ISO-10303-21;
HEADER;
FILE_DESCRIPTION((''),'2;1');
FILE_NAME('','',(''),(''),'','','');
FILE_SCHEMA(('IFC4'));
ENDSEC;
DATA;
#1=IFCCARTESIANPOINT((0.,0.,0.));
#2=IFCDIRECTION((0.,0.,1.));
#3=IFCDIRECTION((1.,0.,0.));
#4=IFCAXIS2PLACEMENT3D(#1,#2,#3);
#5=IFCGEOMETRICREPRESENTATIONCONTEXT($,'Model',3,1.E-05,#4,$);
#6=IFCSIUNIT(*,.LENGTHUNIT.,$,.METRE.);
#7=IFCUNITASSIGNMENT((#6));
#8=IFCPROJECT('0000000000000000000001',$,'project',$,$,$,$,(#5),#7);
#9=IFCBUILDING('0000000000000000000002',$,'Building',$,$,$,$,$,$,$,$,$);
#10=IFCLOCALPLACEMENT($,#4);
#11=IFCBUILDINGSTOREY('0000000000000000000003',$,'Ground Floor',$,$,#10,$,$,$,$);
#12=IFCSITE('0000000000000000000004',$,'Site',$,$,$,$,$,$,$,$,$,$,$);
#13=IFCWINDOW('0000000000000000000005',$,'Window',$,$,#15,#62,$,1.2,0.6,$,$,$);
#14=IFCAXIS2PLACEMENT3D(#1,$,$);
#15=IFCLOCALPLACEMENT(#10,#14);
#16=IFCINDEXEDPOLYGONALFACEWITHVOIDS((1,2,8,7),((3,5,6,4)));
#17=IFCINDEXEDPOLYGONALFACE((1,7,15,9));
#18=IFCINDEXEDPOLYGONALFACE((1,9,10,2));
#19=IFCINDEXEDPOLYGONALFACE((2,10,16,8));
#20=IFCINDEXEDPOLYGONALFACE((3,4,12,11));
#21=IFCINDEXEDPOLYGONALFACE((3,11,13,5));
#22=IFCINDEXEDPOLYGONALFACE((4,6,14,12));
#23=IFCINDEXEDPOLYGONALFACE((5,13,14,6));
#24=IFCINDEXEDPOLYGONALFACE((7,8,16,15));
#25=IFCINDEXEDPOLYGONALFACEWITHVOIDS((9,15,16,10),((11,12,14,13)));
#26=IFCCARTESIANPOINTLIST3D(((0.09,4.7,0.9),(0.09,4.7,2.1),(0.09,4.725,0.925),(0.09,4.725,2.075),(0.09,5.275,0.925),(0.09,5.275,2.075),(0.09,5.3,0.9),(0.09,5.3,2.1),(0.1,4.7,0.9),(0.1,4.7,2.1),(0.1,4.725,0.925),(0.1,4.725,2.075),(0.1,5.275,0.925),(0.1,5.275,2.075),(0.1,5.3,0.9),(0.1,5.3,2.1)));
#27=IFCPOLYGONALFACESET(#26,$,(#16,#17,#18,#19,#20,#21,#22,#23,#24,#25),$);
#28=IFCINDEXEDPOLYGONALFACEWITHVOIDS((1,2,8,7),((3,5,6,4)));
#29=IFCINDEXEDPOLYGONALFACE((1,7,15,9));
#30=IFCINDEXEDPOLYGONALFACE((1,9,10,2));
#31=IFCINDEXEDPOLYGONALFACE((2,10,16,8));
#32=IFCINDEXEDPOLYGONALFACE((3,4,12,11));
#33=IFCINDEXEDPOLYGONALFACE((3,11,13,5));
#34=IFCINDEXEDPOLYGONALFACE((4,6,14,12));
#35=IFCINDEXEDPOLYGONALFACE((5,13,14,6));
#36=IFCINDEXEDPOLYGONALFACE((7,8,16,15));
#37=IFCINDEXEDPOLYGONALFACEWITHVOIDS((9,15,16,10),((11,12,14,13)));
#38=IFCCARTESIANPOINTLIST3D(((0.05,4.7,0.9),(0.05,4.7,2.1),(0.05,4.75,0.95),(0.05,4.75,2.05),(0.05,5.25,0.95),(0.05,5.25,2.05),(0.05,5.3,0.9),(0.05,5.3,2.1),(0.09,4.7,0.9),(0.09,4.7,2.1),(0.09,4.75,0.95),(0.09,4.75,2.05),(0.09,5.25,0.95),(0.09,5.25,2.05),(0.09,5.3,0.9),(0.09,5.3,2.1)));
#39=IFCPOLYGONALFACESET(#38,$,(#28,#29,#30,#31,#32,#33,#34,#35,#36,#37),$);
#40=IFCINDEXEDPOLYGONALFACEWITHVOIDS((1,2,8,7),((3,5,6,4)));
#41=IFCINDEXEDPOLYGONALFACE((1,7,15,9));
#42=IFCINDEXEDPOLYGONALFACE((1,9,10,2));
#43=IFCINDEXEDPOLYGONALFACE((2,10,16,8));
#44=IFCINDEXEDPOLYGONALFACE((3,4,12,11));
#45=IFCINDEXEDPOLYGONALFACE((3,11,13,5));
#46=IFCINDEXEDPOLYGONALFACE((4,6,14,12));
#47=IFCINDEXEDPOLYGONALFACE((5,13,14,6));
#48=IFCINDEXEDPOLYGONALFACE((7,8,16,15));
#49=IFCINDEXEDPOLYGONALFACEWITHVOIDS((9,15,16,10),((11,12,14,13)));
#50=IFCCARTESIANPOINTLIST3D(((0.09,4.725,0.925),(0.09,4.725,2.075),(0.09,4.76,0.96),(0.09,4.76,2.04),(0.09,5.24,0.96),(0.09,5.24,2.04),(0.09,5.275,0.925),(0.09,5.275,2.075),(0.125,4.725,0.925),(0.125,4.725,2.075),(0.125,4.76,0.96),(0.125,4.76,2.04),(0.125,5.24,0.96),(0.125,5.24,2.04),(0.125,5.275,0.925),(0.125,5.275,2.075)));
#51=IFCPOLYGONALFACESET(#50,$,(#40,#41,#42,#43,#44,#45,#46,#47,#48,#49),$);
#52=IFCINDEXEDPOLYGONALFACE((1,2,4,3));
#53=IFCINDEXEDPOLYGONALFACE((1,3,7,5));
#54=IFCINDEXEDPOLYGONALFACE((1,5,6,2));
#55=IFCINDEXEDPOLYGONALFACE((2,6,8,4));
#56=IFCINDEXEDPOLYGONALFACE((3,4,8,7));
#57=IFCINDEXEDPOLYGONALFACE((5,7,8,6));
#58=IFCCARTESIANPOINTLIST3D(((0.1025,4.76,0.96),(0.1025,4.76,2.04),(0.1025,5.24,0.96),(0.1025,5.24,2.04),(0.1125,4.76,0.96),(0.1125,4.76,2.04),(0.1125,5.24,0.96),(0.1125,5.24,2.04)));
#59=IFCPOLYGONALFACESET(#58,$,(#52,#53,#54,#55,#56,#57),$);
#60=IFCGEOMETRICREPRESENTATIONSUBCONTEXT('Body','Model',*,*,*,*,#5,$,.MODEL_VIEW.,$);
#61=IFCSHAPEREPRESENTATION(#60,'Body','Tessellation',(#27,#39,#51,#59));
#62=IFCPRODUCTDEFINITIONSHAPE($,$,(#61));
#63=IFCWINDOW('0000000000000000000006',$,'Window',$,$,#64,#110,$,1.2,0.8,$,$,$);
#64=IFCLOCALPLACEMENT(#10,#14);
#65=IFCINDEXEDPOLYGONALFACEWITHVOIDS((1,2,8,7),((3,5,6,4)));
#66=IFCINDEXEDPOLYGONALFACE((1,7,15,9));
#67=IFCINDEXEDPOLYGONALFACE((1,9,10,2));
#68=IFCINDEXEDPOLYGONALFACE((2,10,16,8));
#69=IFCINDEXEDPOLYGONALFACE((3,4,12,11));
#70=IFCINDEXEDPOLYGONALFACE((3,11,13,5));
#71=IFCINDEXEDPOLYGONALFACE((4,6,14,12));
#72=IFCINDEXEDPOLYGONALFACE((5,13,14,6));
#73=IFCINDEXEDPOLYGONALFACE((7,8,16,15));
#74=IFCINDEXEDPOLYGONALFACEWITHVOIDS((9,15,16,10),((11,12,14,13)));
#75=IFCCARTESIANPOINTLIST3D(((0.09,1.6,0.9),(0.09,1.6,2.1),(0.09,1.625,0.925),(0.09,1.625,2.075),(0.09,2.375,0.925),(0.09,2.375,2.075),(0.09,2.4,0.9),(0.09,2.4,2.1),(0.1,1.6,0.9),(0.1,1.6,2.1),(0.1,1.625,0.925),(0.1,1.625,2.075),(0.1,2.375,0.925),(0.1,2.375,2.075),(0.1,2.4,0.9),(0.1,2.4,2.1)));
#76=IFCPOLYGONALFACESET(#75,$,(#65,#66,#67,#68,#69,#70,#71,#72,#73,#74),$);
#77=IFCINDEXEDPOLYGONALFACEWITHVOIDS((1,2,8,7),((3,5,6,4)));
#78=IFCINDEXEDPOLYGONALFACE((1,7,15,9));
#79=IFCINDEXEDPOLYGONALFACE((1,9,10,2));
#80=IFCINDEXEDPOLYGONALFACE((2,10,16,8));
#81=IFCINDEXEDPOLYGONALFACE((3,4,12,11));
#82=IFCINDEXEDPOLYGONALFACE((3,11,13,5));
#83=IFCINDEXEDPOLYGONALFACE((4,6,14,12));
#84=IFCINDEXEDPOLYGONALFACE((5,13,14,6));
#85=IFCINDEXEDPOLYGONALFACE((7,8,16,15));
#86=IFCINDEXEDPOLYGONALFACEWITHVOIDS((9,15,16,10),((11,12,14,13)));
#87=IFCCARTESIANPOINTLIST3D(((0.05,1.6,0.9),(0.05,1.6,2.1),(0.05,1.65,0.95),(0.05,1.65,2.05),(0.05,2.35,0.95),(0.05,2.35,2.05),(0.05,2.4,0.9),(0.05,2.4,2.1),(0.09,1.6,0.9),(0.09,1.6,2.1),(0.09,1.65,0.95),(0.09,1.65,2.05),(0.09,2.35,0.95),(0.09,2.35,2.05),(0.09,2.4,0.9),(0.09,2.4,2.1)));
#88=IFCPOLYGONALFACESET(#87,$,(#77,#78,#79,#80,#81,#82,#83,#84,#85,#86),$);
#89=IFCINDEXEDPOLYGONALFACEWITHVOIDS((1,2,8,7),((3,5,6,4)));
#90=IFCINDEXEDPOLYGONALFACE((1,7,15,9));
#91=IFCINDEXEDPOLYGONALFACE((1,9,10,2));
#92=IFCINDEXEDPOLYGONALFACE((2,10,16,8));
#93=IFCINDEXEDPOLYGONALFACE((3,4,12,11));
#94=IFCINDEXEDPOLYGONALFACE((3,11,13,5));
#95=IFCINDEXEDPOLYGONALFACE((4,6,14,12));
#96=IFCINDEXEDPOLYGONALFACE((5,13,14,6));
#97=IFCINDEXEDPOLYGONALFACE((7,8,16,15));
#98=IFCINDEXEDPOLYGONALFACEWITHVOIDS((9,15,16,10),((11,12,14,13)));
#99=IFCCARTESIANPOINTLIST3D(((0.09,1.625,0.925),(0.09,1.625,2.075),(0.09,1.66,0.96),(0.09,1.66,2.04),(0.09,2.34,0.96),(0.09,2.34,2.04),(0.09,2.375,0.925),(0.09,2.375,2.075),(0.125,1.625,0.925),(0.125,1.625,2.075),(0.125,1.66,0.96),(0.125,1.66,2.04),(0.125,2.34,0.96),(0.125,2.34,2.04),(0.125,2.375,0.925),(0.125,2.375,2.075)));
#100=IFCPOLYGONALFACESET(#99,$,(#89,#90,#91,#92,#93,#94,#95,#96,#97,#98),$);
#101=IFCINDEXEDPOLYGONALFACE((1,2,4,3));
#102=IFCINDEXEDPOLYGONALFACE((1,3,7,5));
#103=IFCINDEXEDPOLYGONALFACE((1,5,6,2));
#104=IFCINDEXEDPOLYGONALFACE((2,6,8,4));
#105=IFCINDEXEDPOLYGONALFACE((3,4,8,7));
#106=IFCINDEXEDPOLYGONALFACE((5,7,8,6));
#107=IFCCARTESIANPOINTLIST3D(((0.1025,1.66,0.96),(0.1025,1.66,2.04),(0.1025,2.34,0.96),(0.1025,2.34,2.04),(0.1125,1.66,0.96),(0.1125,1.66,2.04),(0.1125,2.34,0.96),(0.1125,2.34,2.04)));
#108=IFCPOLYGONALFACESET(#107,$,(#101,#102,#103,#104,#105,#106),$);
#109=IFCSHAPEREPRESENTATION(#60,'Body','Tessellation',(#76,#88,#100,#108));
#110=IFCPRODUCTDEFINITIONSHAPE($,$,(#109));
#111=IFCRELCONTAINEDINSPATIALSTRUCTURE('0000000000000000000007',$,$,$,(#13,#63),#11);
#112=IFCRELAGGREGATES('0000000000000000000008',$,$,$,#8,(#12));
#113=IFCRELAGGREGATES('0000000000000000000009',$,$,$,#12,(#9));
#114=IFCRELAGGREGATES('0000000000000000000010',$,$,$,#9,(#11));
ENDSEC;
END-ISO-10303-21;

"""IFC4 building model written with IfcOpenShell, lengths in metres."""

from ifc_helpers import new_model, si_unit, frame, origin_with_axes, place, context, subcontext, project, spatial, line, indexed_curve, outline, extrude, element, save


model = new_model("IFC4")

# Units and contexts
model_context = context("Model", 3, precision=1e-05, world=origin_with_axes())
body_context = subcontext(model_context, "Body", "Model", "MODEL_VIEW")
ifc_project = project(units=[si_unit("LENGTHUNIT", "METRE")], contexts=[model_context])

# Site, building, storey
site = spatial("IfcSite", under=ifc_project, Name="Site")
building = spatial("IfcBuilding", under=site, Name="Building")
storey_placement = place(None, origin_with_axes())
storey = spatial("IfcBuildingStorey", under=building, at=storey_placement, Name="Ground Floor")

# Windows
window_1_placement = place(storey_placement, frame((0.0, 5.3, 0.9), z_axis=(0.0, 0.0, 1.0), x_axis=(0.0, -1.0, 0.0)))
element("IfcWindow", 1, at=window_1_placement, inside=storey, Name="Window", OverallHeight=1.2, OverallWidth=0.6, context=body_context, shape_type="SweptSolid", body=[
    extrude(outline(indexed_curve([(0.0, 0.0), (0.6, 0.0), (0.6, 1.2), (0.0, 1.2)], segments=[line(1, 2, 3, 4, 1)]), holes=[indexed_curve([(0.025, 0.025), (0.575, 0.025), (0.575, 1.175), (0.025, 1.175)], segments=[line(1, 2, 3, 4, 1)])]), frame((0.0, 0.09, 0.0), z_axis=(0.0, -1.0, 0.0), x_axis=(1.0, 0.0, 0.0)), (0.0, 0.0, -1.0), 0.01),
    extrude(outline(indexed_curve([(0.0, 0.0), (0.6, 0.0), (0.6, 1.2), (0.0, 1.2)], segments=[line(1, 2, 3, 4, 1)]), holes=[indexed_curve([(0.05, 0.05), (0.55, 0.05), (0.55, 1.15), (0.05, 1.15)], segments=[line(1, 2, 3, 4, 1)])]), frame((0.0, 0.05, 0.0), z_axis=(0.0, -1.0, 0.0), x_axis=(1.0, 0.0, 0.0)), (0.0, 0.0, -1.0), 0.04),
    extrude(outline(indexed_curve([(0.0, 0.0), (0.55, 0.0), (0.55, 1.15), (0.0, 1.15)], segments=[line(1, 2, 3, 4, 1)]), holes=[indexed_curve([(0.035, 0.035), (0.515, 0.035), (0.515, 1.115), (0.035, 1.115)], segments=[line(1, 2, 3, 4, 1)])]), frame((0.025, 0.09, 0.025), z_axis=(0.0, -1.0, 0.0), x_axis=(1.0, 0.0, 0.0)), (0.0, 0.0, -1.0), 0.035),
    extrude(outline(indexed_curve([(0.035, 0.035), (0.515, 0.035), (0.515, 1.115), (0.035, 1.115)], segments=[line(1, 2, 3, 4, 1)])), frame((0.025, 0.1025, 0.025), z_axis=(0.0, -1.0, 0.0), x_axis=(1.0, 0.0, 0.0)), (0.0, 0.0, -1.0), 0.01),
])
window_2_placement = place(storey_placement, frame((0.0, 2.4, 0.9), z_axis=(0.0, 0.0, 1.0), x_axis=(0.0, -1.0, 0.0)))
element("IfcWindow", 2, at=window_2_placement, inside=storey, Name="Window", OverallHeight=1.2, OverallWidth=0.8, context=body_context, shape_type="SweptSolid", body=[
    extrude(outline(indexed_curve([(0.0, 0.0), (0.8, 0.0), (0.8, 1.2), (0.0, 1.2)], segments=[line(1, 2, 3, 4, 1)]), holes=[indexed_curve([(0.025, 0.025), (0.775, 0.025), (0.775, 1.175), (0.025, 1.175)], segments=[line(1, 2, 3, 4, 1)])]), frame((0.0, 0.09, 0.0), z_axis=(0.0, -1.0, 0.0), x_axis=(1.0, 0.0, 0.0)), (0.0, 0.0, -1.0), 0.01),
    extrude(outline(indexed_curve([(0.0, 0.0), (0.8, 0.0), (0.8, 1.2), (0.0, 1.2)], segments=[line(1, 2, 3, 4, 1)]), holes=[indexed_curve([(0.05, 0.05), (0.75, 0.05), (0.75, 1.15), (0.05, 1.15)], segments=[line(1, 2, 3, 4, 1)])]), frame((0.0, 0.05, 0.0), z_axis=(0.0, -1.0, 0.0), x_axis=(1.0, 0.0, 0.0)), (0.0, 0.0, -1.0), 0.04),
    extrude(outline(indexed_curve([(0.0, 0.0), (0.75, 0.0), (0.75, 1.15), (0.0, 1.15)], segments=[line(1, 2, 3, 4, 1)]), holes=[indexed_curve([(0.035, 0.035), (0.715, 0.035), (0.715, 1.115), (0.035, 1.115)], segments=[line(1, 2, 3, 4, 1)])]), frame((0.025, 0.09, 0.025), z_axis=(0.0, -1.0, 0.0), x_axis=(1.0, 0.0, 0.0)), (0.0, 0.0, -1.0), 0.035),
    extrude(outline(indexed_curve([(0.035, 0.035), (0.715, 0.035), (0.715, 1.115), (0.035, 1.115)], segments=[line(1, 2, 3, 4, 1)])), frame((0.025, 0.1025, 0.025), z_axis=(0.0, -1.0, 0.0), x_axis=(1.0, 0.0, 0.0)), (0.0, 0.0, -1.0), 0.01),
])

save(model, "model.ifc")
